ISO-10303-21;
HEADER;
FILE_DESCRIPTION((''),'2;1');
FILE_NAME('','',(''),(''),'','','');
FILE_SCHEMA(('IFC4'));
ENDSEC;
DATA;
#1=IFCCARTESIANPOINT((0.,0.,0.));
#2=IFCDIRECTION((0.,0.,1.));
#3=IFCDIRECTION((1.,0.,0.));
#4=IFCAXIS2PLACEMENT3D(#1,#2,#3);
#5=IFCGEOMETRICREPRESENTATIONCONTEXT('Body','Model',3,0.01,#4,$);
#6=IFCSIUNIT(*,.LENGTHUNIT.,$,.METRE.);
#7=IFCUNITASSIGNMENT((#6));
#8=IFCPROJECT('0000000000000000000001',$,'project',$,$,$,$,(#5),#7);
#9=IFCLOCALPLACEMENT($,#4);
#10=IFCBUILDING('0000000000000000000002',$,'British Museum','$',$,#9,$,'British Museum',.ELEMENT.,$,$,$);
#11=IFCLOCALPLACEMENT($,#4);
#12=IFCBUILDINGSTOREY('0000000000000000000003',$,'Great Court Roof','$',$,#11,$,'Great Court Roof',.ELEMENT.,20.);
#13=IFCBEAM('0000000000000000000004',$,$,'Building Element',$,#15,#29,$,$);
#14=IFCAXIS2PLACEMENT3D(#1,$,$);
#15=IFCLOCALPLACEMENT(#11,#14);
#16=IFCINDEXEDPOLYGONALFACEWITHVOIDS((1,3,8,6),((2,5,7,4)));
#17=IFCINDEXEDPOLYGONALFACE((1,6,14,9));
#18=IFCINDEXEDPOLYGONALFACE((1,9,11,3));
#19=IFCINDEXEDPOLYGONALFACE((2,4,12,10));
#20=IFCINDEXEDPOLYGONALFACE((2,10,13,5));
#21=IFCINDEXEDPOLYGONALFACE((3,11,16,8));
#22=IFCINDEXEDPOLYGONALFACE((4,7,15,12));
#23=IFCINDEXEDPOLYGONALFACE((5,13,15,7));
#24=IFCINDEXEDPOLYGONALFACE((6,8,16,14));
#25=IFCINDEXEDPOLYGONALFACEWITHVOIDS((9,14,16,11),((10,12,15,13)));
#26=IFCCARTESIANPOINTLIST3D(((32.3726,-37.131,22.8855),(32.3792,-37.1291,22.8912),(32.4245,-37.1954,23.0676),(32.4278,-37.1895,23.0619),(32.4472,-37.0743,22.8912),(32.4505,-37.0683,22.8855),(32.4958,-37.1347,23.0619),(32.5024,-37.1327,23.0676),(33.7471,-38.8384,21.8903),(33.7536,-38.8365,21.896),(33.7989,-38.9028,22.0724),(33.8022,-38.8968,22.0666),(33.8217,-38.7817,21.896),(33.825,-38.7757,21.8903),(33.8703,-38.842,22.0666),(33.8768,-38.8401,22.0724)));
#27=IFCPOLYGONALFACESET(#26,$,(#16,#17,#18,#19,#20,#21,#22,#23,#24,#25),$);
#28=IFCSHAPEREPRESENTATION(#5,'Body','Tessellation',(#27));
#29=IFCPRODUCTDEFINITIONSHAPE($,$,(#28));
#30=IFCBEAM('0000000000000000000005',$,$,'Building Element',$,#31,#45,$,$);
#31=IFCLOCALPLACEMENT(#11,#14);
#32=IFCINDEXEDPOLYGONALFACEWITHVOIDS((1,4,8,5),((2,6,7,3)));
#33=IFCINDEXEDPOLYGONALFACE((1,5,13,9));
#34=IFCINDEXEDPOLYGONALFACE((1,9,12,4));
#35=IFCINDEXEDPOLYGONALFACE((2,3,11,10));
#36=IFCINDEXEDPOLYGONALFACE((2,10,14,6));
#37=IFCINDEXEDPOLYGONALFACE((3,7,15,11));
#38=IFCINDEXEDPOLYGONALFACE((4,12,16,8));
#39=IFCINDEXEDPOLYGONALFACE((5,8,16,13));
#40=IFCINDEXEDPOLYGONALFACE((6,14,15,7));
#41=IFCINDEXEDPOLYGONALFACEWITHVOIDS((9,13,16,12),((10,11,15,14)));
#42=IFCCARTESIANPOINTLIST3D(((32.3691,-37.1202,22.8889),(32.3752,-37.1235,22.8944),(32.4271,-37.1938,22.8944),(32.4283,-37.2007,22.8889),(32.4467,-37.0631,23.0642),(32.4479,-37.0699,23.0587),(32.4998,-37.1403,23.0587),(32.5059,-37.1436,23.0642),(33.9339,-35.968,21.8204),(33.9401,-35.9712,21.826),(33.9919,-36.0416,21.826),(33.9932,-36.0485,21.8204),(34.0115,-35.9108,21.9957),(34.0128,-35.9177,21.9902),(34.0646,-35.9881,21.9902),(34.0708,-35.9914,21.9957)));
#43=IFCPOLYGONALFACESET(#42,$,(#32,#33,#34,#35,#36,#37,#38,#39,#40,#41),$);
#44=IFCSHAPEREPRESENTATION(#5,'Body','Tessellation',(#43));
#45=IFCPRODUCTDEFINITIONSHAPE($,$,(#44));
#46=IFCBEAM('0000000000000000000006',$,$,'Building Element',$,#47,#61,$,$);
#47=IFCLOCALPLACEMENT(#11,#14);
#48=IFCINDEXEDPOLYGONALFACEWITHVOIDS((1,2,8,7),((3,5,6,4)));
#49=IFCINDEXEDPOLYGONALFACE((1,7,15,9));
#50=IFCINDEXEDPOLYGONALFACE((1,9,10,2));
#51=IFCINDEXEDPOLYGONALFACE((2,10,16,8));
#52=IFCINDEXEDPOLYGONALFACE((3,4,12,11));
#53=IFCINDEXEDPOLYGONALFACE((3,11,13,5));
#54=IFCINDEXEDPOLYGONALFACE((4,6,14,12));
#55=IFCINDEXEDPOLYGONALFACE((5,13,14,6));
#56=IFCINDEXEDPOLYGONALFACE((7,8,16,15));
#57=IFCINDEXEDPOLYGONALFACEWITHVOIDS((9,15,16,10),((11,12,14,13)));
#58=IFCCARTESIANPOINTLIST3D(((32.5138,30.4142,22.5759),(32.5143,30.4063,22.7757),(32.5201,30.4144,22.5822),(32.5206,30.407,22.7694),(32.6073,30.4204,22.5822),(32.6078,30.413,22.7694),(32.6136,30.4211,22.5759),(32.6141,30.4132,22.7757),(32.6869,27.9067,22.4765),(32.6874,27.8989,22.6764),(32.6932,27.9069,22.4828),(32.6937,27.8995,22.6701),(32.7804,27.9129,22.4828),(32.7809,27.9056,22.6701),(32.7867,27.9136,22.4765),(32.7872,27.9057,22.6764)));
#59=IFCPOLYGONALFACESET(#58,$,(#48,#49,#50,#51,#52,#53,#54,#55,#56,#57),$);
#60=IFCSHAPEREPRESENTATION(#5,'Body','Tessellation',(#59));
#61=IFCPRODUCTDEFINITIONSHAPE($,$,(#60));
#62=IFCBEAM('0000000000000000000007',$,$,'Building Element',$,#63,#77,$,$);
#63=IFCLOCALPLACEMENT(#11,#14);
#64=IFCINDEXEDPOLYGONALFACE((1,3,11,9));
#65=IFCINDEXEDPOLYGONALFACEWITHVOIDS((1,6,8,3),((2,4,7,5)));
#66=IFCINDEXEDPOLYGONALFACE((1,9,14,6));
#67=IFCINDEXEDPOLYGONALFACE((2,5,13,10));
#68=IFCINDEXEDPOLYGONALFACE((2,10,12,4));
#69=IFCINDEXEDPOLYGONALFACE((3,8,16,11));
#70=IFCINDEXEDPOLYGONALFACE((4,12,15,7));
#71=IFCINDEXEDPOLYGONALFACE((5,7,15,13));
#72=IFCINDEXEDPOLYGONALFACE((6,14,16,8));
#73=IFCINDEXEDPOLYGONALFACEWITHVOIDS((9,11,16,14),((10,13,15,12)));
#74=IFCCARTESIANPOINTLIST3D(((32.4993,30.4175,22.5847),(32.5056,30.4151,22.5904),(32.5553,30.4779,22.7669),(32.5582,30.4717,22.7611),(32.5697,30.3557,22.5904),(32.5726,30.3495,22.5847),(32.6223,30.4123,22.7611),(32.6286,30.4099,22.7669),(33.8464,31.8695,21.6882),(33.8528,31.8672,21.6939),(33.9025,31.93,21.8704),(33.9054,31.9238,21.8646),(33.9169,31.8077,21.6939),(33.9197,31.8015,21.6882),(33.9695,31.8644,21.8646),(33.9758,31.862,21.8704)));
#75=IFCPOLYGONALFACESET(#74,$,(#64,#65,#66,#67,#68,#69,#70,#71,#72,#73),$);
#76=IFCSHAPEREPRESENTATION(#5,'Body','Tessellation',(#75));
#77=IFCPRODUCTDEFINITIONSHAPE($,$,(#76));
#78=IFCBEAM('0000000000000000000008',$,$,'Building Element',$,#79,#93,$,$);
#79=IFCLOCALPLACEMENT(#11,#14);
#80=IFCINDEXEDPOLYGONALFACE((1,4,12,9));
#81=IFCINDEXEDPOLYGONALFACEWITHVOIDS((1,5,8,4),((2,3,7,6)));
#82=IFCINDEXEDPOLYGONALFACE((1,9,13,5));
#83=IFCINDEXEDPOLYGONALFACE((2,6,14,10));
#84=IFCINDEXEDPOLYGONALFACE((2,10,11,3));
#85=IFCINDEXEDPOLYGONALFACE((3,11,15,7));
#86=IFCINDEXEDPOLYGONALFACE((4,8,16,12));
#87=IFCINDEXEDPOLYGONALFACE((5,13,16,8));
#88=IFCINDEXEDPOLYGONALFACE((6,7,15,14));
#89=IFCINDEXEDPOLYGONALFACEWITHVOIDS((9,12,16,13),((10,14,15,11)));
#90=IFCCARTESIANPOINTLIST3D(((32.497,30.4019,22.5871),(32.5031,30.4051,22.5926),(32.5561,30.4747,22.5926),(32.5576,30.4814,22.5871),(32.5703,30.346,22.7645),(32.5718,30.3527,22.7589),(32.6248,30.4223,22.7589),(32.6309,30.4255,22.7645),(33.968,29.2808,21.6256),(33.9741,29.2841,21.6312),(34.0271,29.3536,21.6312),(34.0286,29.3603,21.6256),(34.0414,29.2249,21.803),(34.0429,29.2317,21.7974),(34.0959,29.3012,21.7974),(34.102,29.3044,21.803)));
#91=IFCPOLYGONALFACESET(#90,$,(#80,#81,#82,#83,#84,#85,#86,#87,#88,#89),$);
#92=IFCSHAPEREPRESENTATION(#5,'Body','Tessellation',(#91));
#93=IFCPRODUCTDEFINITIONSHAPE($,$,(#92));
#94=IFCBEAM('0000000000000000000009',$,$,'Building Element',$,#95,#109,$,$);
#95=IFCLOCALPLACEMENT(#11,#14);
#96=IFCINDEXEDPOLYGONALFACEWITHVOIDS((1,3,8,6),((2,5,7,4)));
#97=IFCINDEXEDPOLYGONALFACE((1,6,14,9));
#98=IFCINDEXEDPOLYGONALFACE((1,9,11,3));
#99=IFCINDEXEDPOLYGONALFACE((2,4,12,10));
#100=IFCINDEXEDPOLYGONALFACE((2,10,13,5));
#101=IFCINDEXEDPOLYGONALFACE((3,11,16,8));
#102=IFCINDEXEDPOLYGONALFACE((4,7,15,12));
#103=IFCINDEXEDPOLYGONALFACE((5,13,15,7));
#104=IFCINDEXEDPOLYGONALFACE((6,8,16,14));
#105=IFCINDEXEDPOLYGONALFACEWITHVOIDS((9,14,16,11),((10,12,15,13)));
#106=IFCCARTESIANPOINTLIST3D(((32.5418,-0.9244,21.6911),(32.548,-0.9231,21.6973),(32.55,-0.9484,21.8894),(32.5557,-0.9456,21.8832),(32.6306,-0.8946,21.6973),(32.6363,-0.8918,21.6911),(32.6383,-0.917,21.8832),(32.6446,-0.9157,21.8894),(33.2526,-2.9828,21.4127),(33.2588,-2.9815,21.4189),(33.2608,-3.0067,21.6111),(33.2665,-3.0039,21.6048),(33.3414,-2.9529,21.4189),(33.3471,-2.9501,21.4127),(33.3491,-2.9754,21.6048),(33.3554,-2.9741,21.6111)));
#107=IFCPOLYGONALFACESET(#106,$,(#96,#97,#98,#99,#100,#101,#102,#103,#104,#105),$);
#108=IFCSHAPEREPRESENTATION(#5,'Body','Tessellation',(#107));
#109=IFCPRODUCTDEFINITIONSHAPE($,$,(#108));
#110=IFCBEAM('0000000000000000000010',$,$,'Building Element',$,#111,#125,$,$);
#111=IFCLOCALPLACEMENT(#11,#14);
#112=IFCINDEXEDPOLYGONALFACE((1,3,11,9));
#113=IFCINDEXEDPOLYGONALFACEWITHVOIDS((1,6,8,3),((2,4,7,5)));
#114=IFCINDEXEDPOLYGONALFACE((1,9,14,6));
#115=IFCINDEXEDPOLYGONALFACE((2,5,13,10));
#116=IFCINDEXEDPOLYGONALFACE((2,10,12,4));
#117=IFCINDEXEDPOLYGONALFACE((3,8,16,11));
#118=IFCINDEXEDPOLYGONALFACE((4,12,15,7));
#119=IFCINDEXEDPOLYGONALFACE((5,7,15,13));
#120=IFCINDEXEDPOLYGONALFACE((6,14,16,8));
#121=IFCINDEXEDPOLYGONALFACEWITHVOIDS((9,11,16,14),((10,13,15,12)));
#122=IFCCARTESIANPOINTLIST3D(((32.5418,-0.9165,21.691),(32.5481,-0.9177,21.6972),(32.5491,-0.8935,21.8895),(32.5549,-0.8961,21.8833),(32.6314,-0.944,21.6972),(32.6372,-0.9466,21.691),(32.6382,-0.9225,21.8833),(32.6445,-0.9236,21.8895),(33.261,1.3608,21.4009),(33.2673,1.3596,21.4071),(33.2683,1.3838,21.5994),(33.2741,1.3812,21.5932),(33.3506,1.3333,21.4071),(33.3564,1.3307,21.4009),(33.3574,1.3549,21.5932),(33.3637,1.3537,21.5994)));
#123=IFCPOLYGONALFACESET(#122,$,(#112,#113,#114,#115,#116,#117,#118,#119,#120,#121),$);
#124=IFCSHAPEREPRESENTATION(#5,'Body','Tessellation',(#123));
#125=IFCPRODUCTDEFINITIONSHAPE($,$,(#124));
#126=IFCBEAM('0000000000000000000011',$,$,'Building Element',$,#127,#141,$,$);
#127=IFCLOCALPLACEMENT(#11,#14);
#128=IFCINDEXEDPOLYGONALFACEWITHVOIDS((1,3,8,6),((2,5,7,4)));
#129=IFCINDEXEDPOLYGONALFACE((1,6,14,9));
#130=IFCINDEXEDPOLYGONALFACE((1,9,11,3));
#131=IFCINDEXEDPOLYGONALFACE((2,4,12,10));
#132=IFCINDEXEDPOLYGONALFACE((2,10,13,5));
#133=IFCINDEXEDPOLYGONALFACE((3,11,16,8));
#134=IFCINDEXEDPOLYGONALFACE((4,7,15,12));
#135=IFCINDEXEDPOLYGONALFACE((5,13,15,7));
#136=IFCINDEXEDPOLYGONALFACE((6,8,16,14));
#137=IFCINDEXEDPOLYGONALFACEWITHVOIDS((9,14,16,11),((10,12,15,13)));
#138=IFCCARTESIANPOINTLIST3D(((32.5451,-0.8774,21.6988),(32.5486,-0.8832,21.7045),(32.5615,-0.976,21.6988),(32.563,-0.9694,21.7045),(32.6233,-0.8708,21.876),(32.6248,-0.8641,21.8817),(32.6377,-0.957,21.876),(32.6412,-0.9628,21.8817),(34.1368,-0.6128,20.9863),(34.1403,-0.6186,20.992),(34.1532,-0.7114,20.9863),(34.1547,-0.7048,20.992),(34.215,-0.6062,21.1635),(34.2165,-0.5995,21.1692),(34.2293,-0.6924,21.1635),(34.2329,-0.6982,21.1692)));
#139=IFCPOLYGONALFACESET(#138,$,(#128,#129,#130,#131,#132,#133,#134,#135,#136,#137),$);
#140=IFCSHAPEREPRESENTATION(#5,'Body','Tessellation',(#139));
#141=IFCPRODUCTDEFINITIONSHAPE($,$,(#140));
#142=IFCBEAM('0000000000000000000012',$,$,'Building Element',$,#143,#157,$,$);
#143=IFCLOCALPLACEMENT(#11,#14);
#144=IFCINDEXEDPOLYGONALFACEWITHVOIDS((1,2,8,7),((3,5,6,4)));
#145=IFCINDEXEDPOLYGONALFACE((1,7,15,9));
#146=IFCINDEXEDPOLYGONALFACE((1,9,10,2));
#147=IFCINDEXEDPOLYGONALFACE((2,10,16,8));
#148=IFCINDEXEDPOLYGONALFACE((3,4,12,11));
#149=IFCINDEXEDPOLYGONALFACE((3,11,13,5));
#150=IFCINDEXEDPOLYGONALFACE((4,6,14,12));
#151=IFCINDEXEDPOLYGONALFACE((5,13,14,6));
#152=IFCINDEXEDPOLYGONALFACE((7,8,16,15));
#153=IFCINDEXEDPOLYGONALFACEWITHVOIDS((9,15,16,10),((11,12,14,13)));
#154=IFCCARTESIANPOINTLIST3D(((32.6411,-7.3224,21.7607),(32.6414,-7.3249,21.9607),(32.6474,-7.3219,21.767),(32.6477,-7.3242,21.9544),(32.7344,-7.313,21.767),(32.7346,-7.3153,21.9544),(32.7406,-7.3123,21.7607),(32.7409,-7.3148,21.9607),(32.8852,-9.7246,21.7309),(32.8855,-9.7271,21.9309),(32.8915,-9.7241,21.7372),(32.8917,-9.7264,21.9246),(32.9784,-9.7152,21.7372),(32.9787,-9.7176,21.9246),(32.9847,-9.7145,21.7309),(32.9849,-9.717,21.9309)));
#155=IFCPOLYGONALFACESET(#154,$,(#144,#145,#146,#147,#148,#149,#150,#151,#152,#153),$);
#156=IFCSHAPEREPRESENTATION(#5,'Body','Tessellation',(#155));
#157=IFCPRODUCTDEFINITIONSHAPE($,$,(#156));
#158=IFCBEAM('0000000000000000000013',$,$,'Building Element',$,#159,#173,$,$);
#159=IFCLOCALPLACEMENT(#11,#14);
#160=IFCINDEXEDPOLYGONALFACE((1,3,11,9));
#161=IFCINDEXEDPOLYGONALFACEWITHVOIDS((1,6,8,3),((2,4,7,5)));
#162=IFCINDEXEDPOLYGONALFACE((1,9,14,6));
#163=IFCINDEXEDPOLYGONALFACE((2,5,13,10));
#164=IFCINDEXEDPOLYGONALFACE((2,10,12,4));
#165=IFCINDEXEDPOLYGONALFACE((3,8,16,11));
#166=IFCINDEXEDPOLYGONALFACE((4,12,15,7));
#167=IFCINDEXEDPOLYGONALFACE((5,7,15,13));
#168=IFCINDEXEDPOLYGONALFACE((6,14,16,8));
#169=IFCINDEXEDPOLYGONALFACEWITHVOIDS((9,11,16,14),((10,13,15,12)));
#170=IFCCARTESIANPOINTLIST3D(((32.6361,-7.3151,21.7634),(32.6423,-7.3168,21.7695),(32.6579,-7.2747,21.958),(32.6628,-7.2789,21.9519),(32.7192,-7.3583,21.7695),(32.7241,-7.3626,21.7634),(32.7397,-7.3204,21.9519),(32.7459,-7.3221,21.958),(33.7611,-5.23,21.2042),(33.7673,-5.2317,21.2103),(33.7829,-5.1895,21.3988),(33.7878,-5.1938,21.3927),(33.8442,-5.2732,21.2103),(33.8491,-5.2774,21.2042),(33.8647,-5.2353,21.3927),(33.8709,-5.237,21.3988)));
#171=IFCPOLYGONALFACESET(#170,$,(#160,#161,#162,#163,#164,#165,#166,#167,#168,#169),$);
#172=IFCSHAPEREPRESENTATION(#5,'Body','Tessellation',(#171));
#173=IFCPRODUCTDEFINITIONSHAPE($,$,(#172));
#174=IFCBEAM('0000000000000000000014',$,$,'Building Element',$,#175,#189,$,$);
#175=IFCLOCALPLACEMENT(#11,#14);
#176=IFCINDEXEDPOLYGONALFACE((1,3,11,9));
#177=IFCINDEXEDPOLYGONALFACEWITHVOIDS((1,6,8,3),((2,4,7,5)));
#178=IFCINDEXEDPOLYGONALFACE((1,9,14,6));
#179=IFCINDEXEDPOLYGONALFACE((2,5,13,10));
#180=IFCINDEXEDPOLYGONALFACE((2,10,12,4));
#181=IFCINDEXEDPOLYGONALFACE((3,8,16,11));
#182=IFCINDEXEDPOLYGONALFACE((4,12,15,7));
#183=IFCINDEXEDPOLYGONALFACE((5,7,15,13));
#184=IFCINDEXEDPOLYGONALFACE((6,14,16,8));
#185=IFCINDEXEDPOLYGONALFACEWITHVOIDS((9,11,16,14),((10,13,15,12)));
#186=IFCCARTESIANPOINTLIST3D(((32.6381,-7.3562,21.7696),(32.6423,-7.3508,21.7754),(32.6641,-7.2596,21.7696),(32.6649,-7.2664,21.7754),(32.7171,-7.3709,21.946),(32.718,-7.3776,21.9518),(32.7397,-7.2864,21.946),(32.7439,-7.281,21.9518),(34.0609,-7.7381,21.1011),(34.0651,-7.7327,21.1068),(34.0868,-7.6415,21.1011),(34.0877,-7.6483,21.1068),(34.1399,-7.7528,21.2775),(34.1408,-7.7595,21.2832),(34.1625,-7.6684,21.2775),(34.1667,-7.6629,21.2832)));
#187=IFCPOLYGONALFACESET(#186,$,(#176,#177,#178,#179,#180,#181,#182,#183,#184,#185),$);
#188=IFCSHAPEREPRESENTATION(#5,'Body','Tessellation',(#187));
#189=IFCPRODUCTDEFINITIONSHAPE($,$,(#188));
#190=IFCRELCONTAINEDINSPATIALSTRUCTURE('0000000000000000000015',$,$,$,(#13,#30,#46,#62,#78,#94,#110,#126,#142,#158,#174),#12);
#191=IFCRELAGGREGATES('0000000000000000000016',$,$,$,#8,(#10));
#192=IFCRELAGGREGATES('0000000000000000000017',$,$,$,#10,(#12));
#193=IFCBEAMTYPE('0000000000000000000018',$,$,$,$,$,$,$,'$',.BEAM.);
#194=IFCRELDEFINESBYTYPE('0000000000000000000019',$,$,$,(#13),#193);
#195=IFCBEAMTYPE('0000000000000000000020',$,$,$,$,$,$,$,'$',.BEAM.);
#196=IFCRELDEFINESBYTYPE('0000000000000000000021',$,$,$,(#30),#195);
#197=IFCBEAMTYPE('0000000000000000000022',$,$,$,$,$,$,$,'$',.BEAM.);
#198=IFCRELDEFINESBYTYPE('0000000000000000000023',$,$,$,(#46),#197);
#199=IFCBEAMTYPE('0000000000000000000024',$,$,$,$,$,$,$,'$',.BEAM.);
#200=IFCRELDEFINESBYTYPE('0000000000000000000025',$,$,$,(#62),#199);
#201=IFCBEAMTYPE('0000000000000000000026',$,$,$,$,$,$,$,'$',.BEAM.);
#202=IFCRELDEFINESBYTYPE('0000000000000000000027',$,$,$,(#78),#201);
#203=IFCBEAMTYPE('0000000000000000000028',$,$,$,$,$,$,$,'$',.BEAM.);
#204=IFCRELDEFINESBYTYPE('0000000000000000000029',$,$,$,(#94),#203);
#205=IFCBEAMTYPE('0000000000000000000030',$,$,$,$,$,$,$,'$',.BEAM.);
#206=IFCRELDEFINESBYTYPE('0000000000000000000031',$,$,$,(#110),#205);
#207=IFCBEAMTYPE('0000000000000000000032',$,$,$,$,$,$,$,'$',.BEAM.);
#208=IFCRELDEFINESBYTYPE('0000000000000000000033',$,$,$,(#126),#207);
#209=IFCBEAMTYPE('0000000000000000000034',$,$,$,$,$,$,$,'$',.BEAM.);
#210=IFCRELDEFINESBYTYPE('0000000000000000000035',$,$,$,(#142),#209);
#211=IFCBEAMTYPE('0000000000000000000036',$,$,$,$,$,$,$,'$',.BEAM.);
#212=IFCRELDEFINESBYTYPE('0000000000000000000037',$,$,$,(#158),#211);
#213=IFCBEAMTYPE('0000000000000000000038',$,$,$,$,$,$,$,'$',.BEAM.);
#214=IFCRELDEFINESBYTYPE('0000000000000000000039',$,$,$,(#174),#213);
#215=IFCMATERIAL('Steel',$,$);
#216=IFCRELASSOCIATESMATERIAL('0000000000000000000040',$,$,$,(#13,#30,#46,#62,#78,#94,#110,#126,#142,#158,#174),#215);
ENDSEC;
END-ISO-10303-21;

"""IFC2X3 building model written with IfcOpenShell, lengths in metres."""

from ifc_helpers import new_model, si_unit, frame, origin_with_axes, origin_2d, place, context, project, spatial, hollow_rectangle, extrude, material, type_object, element, save


model = new_model("IFC2X3")

# Units and contexts
model_context = context("Model", 3, precision=0.01, world=origin_with_axes(), identifier="Body")
ifc_project = project(units=[si_unit("LENGTHUNIT", "METRE")], contexts=[model_context])

# Building, storey
building_placement = place(None, origin_with_axes())
building = spatial("IfcBuilding", under=ifc_project, at=building_placement, Name="British Museum", Description="$", LongName="British Museum", CompositionType="ELEMENT")
storey_placement = place(None, origin_with_axes())
storey = spatial("IfcBuildingStorey", under=building, at=storey_placement, Name="Great Court Roof", Description="$", LongName="Great Court Roof", CompositionType="ELEMENT", Elevation=20.0)

# Beams
ifc_material = material(Name="Steel")
beam_type_1 = type_object("IfcBeamType", ElementType="$", PredefinedType="BEAM")
beam_1_placement = place(None, origin_with_axes())
element("IfcBeam", 1, at=beam_1_placement, inside=storey, type_object=beam_type_1, material=ifc_material, Description="Building Element", context=model_context, shape_type="SweptSolid", body=[
    extrude(hollow_rectangle(XDim=0.1, YDim=0.2, WallThickness=0.0063, InnerFilletRadius=0.0, OuterFilletRadius=0.0, at=origin_2d()), frame((32.4375, -37.1319, 22.9765), z_axis=(0.570973, -0.709267, -0.413437), x_axis=(0.778958, 0.627076, 0.0)), (0.0, 0.0, 1.0), 2.4072),
])
beam_type_2 = type_object("IfcBeamType", ElementType="$", PredefinedType="BEAM")
beam_2_placement = place(None, origin_with_axes())
element("IfcBeam", 2, at=beam_2_placement, inside=storey, type_object=beam_type_2, material=ifc_material, Description="Building Element", context=model_context, shape_type="SweptSolid", body=[
    extrude(hollow_rectangle(XDim=0.1, YDim=0.2, WallThickness=0.0063, InnerFilletRadius=0.0, OuterFilletRadius=0.0, at=origin_2d()), frame((32.4375, -37.1319, 22.9765), z_axis=(0.705632, 0.519568, -0.481801), x_axis=(-0.592925, 0.805258, 0.0)), (0.0, 0.0, 1.0), 2.2177),
])
beam_type_3 = type_object("IfcBeamType", ElementType="$", PredefinedType="BEAM")
beam_3_placement = place(None, origin_with_axes())
element("IfcBeam", 3, at=beam_3_placement, inside=storey, type_object=beam_type_3, material=ifc_material, Description="Building Element", context=model_context, shape_type="SweptSolid", body=[
    extrude(hollow_rectangle(XDim=0.1, YDim=0.2, WallThickness=0.0063, InnerFilletRadius=0.0, OuterFilletRadius=0.0, at=origin_2d()), frame((32.5639, 30.4137, 22.6758), z_axis=(0.068813, -0.996848, -0.039483), x_axis=(0.997626, 0.068866, 0.0)), (0.0, 0.0, 1.0), 2.5154),
])
beam_type_4 = type_object("IfcBeamType", ElementType="$", PredefinedType="BEAM")
beam_4_placement = place(None, origin_with_axes())
element("IfcBeam", 4, at=beam_4_placement, inside=storey, type_object=beam_type_4, material=ifc_material, Description="Building Element", context=model_context, shape_type="SweptSolid", body=[
    extrude(hollow_rectangle(XDim=0.1, YDim=0.2, WallThickness=0.0063, InnerFilletRadius=0.0, OuterFilletRadius=0.0, at=origin_2d()), frame((32.5639, 30.4137, 22.6758), z_axis=(0.619626, 0.66786, -0.412344), x_axis=(-0.733083, 0.680139, 0.0)), (0.0, 0.0, 1.0), 2.1742),
])
beam_type_5 = type_object("IfcBeamType", ElementType="$", PredefinedType="BEAM")
beam_5_placement = place(None, origin_with_axes())
element("IfcBeam", 5, at=beam_5_placement, inside=storey, type_object=beam_type_5, material=ifc_material, Description="Building Element", context=model_context, shape_type="SweptSolid", body=[
    extrude(hollow_rectangle(XDim=0.1, YDim=0.2, WallThickness=0.0063, InnerFilletRadius=0.0, OuterFilletRadius=0.0, at=origin_2d()), frame((32.5639, 30.4137, 22.6758), z_axis=(0.7057, -0.537808, -0.461248), x_axis=(0.606137, 0.79536, 0.0)), (0.0, 0.0, 1.0), 2.0845),
])
beam_type_6 = type_object("IfcBeamType", ElementType="$", PredefinedType="BEAM")
beam_6_placement = place(None, origin_with_axes())
element("IfcBeam", 6, at=beam_6_placement, inside=storey, type_object=beam_type_6, material=ifc_material, Description="Building Element", context=model_context, shape_type="SweptSolid", body=[
    extrude(hollow_rectangle(XDim=0.1, YDim=0.2, WallThickness=0.0063, InnerFilletRadius=0.0, OuterFilletRadius=0.0, at=origin_2d()), frame((32.5932, -0.9201, 21.7902), z_axis=(0.323776, -0.937598, -0.126802), x_axis=(0.945228, 0.32641, 0.0)), (0.0, 0.0, 1.0), 2.1953),
])
beam_type_7 = type_object("IfcBeamType", ElementType="$", PredefinedType="BEAM")
beam_7_placement = place(None, origin_with_axes())
element("IfcBeam", 7, at=beam_7_placement, inside=storey, type_object=beam_type_7, material=ifc_material, Description="Building Element", context=model_context, shape_type="SweptSolid", body=[
    extrude(hollow_rectangle(XDim=0.1, YDim=0.2, WallThickness=0.0063, InnerFilletRadius=0.0, OuterFilletRadius=0.0, at=origin_2d()), frame((32.5932, -0.9201, 21.7902), z_axis=(0.298949, 0.94662, -0.120584), x_axis=(-0.953578, 0.301146, 0.0)), (0.0, 0.0, 1.0), 2.4057),
])
beam_type_8 = type_object("IfcBeamType", ElementType="$", PredefinedType="BEAM")
beam_8_placement = place(None, origin_with_axes())
element("IfcBeam", 8, at=beam_8_placement, inside=storey, type_object=beam_type_8, material=ifc_material, Description="Building Element", context=model_context, shape_type="SweptSolid", body=[
    extrude(hollow_rectangle(XDim=0.1, YDim=0.2, WallThickness=0.0063, InnerFilletRadius=0.0, OuterFilletRadius=0.0, at=origin_2d()), frame((32.5932, -0.9201, 21.7902), z_axis=(0.902403, 0.150007, -0.403939), x_axis=(-0.16398, 0.986464, 0.0)), (0.0, 0.0, 1.0), 1.7638),
])
beam_type_9 = type_object("IfcBeamType", ElementType="$", PredefinedType="BEAM")
beam_9_placement = place(None, origin_with_axes())
element("IfcBeam", 9, at=beam_9_placement, inside=storey, type_object=beam_type_9, material=ifc_material, Description="Building Element", context=model_context, shape_type="SweptSolid", body=[
    extrude(hollow_rectangle(XDim=0.1, YDim=0.2, WallThickness=0.0063, InnerFilletRadius=0.0, OuterFilletRadius=0.0, at=origin_2d()), frame((32.691, -7.3186, 21.8607), z_axis=(0.10107, -0.994803, -0.012347), x_axis=(0.994879, 0.101078, 0.0)), (0.0, 0.0, 1.0), 2.4148),
])
beam_type_10 = type_object("IfcBeamType", ElementType="$", PredefinedType="BEAM")
beam_10_placement = place(None, origin_with_axes())
element("IfcBeam", 10, at=beam_10_placement, inside=storey, type_object=beam_type_10, material=ifc_material, Description="Building Element", context=model_context, shape_type="SweptSolid", body=[
    extrude(hollow_rectangle(XDim=0.1, YDim=0.2, WallThickness=0.0063, InnerFilletRadius=0.0, OuterFilletRadius=0.0, at=origin_2d()), frame((32.691, -7.3186, 21.8607), z_axis=(0.462134, 0.856543, -0.229708), x_axis=(-0.880077, 0.474831, 0.0)), (0.0, 0.0, 1.0), 2.4344),
])
beam_type_11 = type_object("IfcBeamType", ElementType="$", PredefinedType="BEAM")
beam_11_placement = place(None, origin_with_axes())
element("IfcBeam", 11, at=beam_11_placement, inside=storey, type_object=beam_type_11, material=ifc_material, Description="Building Element", context=model_context, shape_type="SweptSolid", body=[
    extrude(hollow_rectangle(XDim=0.1, YDim=0.2, WallThickness=0.0063, InnerFilletRadius=0.0, OuterFilletRadius=0.0, at=origin_2d()), frame((32.691, -7.3186, 21.8607), z_axis=(0.879483, -0.236071, -0.413257), x_axis=(0.259243, 0.965812, 0.0)), (0.0, 0.0, 1.0), 1.6178),
])

save(model, "model.ifc")
